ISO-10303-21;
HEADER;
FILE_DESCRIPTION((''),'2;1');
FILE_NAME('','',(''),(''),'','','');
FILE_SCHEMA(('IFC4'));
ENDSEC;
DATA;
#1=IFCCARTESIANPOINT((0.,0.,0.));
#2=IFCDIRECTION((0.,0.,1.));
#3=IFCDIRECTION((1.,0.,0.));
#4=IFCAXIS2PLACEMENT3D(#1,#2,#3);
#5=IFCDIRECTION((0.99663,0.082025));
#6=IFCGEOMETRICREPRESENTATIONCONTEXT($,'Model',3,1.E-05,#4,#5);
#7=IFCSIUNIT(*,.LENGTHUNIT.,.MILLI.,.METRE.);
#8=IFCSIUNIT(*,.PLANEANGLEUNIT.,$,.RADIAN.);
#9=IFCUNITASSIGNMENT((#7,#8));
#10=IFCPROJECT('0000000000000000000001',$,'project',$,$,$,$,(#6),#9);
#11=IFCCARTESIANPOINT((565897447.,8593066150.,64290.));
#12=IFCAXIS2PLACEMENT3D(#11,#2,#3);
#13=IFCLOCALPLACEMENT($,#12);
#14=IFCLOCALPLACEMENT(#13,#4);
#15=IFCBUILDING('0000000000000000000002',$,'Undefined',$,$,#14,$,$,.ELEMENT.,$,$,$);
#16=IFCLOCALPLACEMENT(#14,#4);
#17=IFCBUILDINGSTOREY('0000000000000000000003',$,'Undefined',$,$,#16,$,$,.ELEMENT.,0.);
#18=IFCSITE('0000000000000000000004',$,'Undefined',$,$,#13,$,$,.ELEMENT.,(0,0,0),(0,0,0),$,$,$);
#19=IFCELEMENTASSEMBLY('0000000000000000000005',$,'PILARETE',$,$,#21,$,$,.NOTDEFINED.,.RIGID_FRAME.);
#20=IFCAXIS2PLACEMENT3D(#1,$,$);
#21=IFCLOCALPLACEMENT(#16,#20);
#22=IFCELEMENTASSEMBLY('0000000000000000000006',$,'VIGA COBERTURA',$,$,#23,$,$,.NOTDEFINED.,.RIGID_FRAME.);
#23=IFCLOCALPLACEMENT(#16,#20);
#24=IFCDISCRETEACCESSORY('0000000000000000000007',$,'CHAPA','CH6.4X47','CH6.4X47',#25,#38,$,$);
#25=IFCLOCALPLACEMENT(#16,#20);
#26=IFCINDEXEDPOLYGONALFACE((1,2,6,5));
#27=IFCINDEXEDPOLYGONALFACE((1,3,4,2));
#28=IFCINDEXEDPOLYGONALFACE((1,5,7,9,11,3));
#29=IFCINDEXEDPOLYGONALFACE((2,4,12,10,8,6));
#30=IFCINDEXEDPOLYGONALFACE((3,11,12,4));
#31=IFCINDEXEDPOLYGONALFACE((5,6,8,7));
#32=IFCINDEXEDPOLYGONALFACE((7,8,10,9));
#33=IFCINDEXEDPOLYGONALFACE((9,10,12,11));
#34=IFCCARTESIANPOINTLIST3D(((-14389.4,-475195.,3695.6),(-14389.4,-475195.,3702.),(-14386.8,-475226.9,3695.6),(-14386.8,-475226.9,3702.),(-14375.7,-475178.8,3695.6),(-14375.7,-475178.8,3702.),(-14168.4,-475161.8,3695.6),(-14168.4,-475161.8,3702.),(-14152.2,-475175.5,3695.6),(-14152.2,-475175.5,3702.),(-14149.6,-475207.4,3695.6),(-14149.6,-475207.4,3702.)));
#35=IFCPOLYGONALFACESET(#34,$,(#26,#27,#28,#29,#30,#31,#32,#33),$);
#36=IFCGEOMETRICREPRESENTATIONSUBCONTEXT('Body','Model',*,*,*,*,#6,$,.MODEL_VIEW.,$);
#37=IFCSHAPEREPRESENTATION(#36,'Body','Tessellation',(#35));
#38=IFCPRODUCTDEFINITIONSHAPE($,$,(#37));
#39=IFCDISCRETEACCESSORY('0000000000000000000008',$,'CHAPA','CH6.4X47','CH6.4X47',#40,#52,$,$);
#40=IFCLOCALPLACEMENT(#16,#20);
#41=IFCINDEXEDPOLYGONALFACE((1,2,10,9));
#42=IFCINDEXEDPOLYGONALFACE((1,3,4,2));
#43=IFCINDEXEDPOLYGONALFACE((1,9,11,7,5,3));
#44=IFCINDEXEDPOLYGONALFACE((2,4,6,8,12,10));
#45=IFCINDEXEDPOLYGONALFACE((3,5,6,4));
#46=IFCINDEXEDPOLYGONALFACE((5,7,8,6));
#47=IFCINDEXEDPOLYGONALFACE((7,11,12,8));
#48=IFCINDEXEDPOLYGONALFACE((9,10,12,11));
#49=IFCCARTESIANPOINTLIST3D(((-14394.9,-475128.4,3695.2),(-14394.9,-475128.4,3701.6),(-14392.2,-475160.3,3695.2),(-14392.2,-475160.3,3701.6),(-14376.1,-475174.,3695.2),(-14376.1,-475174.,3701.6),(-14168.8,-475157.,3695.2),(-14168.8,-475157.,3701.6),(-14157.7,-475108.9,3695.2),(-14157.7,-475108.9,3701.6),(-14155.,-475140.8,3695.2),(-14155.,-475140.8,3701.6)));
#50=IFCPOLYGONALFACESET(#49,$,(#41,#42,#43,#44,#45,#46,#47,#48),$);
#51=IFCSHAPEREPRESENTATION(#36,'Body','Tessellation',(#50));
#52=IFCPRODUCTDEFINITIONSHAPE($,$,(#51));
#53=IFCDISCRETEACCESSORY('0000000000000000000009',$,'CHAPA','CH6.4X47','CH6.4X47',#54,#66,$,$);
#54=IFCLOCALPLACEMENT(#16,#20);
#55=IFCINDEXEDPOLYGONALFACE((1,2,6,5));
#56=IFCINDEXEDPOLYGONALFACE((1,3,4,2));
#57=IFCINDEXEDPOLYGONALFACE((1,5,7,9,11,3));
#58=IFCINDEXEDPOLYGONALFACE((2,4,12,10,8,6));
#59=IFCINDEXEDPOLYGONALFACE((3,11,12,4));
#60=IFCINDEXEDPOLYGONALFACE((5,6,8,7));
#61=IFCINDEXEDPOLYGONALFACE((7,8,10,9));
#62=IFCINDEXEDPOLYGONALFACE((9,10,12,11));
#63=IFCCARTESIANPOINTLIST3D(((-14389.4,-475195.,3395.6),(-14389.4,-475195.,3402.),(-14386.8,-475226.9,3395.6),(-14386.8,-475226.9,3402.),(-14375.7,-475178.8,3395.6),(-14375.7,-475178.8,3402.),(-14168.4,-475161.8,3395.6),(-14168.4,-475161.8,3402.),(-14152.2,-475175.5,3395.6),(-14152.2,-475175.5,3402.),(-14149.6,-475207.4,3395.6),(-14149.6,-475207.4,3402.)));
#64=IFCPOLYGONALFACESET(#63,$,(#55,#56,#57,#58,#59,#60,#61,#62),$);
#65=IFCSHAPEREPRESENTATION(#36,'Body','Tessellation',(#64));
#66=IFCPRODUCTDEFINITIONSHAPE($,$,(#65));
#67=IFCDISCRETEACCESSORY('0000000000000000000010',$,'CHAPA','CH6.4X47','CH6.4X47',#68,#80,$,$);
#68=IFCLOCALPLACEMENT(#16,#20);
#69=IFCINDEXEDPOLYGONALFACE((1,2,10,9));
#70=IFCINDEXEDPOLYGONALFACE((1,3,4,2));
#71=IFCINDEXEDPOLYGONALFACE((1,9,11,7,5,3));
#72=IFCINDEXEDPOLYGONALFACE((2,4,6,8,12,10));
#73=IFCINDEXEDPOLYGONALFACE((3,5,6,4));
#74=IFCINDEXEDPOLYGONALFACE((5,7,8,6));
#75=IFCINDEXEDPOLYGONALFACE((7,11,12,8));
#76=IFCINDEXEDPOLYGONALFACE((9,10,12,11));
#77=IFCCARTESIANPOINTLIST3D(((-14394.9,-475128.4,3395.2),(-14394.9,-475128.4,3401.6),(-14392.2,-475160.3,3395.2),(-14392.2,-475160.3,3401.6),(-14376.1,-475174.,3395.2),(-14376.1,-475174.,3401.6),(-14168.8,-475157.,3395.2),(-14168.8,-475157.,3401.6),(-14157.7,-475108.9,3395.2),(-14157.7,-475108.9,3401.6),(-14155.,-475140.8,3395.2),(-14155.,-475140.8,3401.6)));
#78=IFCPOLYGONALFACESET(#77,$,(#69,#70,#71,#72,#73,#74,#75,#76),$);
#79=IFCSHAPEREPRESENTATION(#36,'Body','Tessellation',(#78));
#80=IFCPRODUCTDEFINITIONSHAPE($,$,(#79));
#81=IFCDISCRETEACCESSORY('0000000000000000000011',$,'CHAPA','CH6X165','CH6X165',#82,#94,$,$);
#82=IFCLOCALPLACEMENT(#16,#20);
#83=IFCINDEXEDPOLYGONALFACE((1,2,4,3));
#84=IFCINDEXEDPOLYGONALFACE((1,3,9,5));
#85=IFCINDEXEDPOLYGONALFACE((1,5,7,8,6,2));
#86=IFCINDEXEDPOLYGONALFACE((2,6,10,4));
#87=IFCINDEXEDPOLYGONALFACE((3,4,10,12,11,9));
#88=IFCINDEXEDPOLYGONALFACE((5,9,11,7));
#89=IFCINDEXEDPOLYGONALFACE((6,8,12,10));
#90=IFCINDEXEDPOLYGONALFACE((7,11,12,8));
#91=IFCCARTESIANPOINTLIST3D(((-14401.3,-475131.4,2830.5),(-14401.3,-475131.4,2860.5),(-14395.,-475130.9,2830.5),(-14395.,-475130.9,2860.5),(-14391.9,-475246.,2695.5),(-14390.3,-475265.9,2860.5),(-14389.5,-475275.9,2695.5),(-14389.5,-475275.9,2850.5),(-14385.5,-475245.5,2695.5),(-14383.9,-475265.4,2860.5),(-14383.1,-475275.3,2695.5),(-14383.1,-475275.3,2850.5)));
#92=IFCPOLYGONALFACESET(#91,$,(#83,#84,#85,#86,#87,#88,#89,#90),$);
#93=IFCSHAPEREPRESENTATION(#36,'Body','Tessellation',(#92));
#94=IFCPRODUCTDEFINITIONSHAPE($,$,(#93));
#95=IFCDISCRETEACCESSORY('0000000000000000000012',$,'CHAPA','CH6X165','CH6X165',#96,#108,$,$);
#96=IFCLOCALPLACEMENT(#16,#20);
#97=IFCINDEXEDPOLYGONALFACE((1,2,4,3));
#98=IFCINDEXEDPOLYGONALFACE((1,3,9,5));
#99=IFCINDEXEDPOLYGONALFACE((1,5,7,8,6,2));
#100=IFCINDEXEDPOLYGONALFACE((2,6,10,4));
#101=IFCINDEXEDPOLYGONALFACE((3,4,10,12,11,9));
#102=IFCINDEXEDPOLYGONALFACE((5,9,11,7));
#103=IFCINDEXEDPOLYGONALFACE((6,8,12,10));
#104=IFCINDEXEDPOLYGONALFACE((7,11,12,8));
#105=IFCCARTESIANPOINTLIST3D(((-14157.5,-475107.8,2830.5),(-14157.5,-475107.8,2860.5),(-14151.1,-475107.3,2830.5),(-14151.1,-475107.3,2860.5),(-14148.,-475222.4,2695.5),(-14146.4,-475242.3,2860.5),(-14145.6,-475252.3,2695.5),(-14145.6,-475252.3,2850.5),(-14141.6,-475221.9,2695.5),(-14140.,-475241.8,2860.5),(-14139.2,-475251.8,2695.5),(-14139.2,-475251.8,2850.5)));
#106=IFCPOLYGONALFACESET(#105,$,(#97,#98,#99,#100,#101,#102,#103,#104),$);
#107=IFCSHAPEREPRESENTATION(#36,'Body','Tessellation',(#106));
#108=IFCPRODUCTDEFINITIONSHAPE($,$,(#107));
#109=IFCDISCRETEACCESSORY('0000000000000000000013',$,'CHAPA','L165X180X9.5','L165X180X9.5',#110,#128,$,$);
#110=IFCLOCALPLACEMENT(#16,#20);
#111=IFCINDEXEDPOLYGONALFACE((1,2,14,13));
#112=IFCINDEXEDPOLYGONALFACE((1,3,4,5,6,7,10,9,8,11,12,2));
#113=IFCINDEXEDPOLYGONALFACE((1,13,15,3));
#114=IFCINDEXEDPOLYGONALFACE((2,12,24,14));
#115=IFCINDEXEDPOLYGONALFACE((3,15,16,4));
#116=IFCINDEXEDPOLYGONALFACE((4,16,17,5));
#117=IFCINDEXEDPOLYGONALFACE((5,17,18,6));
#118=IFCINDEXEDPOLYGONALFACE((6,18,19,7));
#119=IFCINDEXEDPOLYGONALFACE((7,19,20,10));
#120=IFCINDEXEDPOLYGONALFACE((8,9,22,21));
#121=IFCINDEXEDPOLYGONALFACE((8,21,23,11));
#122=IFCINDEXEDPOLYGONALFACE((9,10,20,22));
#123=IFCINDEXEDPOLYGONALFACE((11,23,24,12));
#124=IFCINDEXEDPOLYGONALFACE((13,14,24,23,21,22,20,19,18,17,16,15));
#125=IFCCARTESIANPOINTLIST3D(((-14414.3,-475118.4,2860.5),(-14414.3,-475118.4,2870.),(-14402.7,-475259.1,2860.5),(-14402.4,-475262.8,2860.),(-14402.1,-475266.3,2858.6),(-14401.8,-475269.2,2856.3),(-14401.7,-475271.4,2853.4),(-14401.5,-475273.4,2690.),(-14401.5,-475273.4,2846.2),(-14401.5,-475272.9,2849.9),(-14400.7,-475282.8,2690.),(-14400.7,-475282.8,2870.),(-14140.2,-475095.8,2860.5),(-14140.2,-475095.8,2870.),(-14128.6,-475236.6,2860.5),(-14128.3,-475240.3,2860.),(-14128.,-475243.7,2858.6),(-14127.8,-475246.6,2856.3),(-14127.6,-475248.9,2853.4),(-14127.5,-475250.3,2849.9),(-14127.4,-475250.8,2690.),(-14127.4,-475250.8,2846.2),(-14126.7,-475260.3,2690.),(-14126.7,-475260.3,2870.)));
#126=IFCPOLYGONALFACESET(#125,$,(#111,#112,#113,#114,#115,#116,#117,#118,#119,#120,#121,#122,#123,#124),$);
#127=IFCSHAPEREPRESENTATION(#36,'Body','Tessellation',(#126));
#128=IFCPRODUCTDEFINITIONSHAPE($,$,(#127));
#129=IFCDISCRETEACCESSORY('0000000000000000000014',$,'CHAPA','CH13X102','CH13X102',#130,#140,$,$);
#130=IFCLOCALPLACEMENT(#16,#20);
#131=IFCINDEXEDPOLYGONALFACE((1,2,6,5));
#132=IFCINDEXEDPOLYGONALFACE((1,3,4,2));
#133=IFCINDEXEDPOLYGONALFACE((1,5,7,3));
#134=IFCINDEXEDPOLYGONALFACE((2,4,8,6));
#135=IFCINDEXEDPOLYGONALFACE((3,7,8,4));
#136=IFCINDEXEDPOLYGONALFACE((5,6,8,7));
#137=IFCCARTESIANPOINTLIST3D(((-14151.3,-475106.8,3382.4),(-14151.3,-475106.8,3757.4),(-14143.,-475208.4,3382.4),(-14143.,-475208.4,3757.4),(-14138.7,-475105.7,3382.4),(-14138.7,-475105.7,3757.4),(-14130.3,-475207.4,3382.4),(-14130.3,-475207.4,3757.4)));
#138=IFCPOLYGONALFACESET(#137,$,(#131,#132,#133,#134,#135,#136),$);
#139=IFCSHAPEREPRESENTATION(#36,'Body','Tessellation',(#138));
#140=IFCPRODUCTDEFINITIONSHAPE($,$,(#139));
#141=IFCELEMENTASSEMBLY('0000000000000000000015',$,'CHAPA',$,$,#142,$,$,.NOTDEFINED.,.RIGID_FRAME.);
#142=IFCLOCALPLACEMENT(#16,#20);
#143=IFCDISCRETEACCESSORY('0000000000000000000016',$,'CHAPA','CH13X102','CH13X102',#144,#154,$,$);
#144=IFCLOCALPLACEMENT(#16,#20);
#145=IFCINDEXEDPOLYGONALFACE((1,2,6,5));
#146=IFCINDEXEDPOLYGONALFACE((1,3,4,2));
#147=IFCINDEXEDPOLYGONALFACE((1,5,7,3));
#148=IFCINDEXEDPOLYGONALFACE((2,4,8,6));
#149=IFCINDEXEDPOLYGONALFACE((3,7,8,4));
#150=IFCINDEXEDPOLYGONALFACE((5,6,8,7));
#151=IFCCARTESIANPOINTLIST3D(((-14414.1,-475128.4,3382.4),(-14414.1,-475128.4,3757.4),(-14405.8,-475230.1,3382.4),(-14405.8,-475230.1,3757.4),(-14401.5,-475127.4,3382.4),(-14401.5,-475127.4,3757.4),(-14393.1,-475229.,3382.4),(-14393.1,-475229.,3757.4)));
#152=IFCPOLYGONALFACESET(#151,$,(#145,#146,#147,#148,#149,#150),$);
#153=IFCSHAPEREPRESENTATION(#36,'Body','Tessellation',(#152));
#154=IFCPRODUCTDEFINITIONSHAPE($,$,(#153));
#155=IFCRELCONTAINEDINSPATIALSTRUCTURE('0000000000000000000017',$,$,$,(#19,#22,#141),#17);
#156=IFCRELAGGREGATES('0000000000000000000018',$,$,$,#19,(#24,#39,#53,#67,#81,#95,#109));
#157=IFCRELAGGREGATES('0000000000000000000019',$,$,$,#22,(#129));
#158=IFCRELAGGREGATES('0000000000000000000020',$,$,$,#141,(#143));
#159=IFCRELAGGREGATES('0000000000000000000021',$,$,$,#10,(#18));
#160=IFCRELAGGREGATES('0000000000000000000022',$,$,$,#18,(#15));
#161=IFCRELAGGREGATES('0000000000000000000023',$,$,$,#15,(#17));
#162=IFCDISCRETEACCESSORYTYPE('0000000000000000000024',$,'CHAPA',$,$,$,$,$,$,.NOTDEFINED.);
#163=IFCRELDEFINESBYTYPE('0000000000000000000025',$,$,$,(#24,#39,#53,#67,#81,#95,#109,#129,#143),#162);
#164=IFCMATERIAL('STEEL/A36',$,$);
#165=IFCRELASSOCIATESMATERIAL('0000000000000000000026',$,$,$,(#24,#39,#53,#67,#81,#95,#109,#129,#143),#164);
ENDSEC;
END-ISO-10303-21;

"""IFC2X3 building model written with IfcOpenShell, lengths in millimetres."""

from ifc_helpers import new_model, si_unit, direction, frame, origin_with_axes, origin_2d_with_axis, place, context, subcontext, project, spatial, polyline, l_section, outline, extrude, material, type_object, element, aggregate, save


model = new_model("IFC2X3")

# Units and contexts
model_context = context("Model", 3, precision=1e-05, world=origin_with_axes(), true_north=direction((0.99663, 0.082025)))
body_context = subcontext(model_context, "Body", "Model", "MODEL_VIEW")
ifc_project = project(units=[si_unit("LENGTHUNIT", "METRE", prefix="MILLI"), si_unit("PLANEANGLEUNIT", "RADIAN")], contexts=[model_context])

# Site, building, storey
site_placement = place(None, frame((565897447.0, 8593066150.0, 64290.0), z_axis=(0.0, 0.0, 1.0), x_axis=(1.0, 0.0, 0.0)))
site = spatial("IfcSite", under=ifc_project, at=site_placement, Name="Undefined", CompositionType="ELEMENT", RefLatitude=(0, 0, 0), RefLongitude=(0, 0, 0))
building_placement = place(site_placement, origin_with_axes())
building = spatial("IfcBuilding", under=site, at=building_placement, Name="Undefined", CompositionType="ELEMENT")
storey_placement = place(building_placement, origin_with_axes())
storey = spatial("IfcBuildingStorey", under=building, at=storey_placement, Name="Undefined", CompositionType="ELEMENT", Elevation=0.0)

# Element assembly
assembly_1_placement = place(storey_placement, origin_with_axes())
assembly_1 = element("IfcElementAssembly", 1, at=assembly_1_placement, inside=storey, Name="PILARETE", AssemblyPlace="NOTDEFINED", PredefinedType="RIGID_FRAME")

# Element assembly
ifc_material_1 = material(Name="STEEL/A36")
assembly_2_placement = place(storey_placement, origin_with_axes())
assembly_2 = element("IfcElementAssembly", 2, at=assembly_2_placement, inside=storey, Name="VIGA COBERTURA", AssemblyPlace="NOTDEFINED", PredefinedType="RIGID_FRAME")

# Discrete accessories
discrete_accessory_type_1 = type_object("IfcDiscreteAccessoryType", Name="CHAPA")
discrete_accessory_1_placement = place(assembly_1_placement, frame((-14153.4, -475160.5, 3698.8), z_axis=(0.0, 0.0, -1.0), x_axis=(0.082025, -0.99663, 0.0)))
discrete_accessory_1 = element("IfcDiscreteAccessory", 3, at=discrete_accessory_1_placement, type_object=discrete_accessory_type_1, material=ifc_material_1, Name="CHAPA", Description="CH6.4X47", ObjectType="CH6.4X47", context=body_context, shape_type="SweptSolid", body=[
    extrude(outline(polyline([(0.0, 15.0), (15.0, 0.0), (47.0, 0.0), (47.0, 238.0), (15.0, 238.0), (0.0, 223.0), (0.0, 15.0)])), frame((0.0, 0.0, -3.2), z_axis=(0.0, 0.0, 1.0), x_axis=(1.0, 0.0, 0.0)), (0.0, 0.0, 1.0), 6.4),
])
discrete_accessory_2_placement = place(assembly_1_placement, frame((-14153.8, -475155.7, 3698.4), z_axis=(0.0, 0.0, 1.0), x_axis=(-0.082025, 0.99663, 0.0)))
discrete_accessory_2 = element("IfcDiscreteAccessory", 4, at=discrete_accessory_2_placement, type_object=discrete_accessory_type_1, material=ifc_material_1, Name="CHAPA", Description="CH6.4X47", ObjectType="CH6.4X47", context=body_context, shape_type="SweptSolid", body=[
    extrude(outline(polyline([(0.0, 15.0), (15.0, 0.0), (47.0, 0.0), (47.0, 238.0), (15.0, 238.0), (0.0, 223.0), (0.0, 15.0)])), frame((0.0, 0.0, -3.2), z_axis=(0.0, 0.0, 1.0), x_axis=(1.0, 0.0, 0.0)), (0.0, 0.0, 1.0), 6.4),
])
discrete_accessory_3_placement = place(assembly_1_placement, frame((-14153.4, -475160.5, 3398.8), z_axis=(0.0, 0.0, -1.0), x_axis=(0.082025, -0.99663, 0.0)))
discrete_accessory_3 = element("IfcDiscreteAccessory", 5, at=discrete_accessory_3_placement, type_object=discrete_accessory_type_1, material=ifc_material_1, Name="CHAPA", Description="CH6.4X47", ObjectType="CH6.4X47", context=body_context, shape_type="SweptSolid", body=[
    extrude(outline(polyline([(0.0, 15.0), (15.0, 0.0), (47.0, 0.0), (47.0, 238.0), (15.0, 238.0), (0.0, 223.0), (0.0, 15.0)])), frame((0.0, 0.0, -3.2), z_axis=(0.0, 0.0, 1.0), x_axis=(1.0, 0.0, 0.0)), (0.0, 0.0, 1.0), 6.4),
])
discrete_accessory_4_placement = place(assembly_1_placement, frame((-14153.8, -475155.7, 3398.4), z_axis=(0.0, 0.0, 1.0), x_axis=(-0.082025, 0.99663, 0.0)))
discrete_accessory_4 = element("IfcDiscreteAccessory", 6, at=discrete_accessory_4_placement, type_object=discrete_accessory_type_1, material=ifc_material_1, Name="CHAPA", Description="CH6.4X47", ObjectType="CH6.4X47", context=body_context, shape_type="SweptSolid", body=[
    extrude(outline(polyline([(0.0, 15.0), (15.0, 0.0), (47.0, 0.0), (47.0, 238.0), (15.0, 238.0), (0.0, 223.0), (0.0, 15.0)])), frame((0.0, 0.0, -3.2), z_axis=(0.0, 0.0, 1.0), x_axis=(1.0, 0.0, 0.0)), (0.0, 0.0, 1.0), 6.4),
])
discrete_accessory_5_placement = place(assembly_1_placement, frame((-14386.3, -475275.6, 2860.5), z_axis=(0.99663, 0.082025, -0.000004), x_axis=(-0.000004, 0.0, -1.0)))
discrete_accessory_5 = element("IfcDiscreteAccessory", 7, at=discrete_accessory_5_placement, type_object=discrete_accessory_type_1, material=ifc_material_1, Name="CHAPA", Description="CH6X165", ObjectType="CH6X165", context=body_context, shape_type="SweptSolid", body=[
    extrude(outline(polyline([(0.0, 10.0), (10.0, 0.0), (165.0, 0.0), (165.0, 30.0), (30.0, 145.0), (0.0, 145.0), (0.0, 10.0)])), frame((0.0, 0.0, -3.2), z_axis=(0.0, 0.0, 1.0), x_axis=(1.0, 0.0, 0.0)), (0.0, 0.0, 1.0), 6.4),
])
discrete_accessory_6_placement = place(assembly_1_placement, frame((-14142.4, -475252.0, 2860.5), z_axis=(0.99663, 0.082025, 0.000004), x_axis=(0.000004, 0.0, -1.0)))
discrete_accessory_6 = element("IfcDiscreteAccessory", 8, at=discrete_accessory_6_placement, type_object=discrete_accessory_type_1, material=ifc_material_1, Name="CHAPA", Description="CH6X165", ObjectType="CH6X165", context=body_context, shape_type="SweptSolid", body=[
    extrude(outline(polyline([(0.0, 10.0), (10.0, 0.0), (165.0, 0.0), (165.0, 30.0), (30.0, 145.0), (0.0, 145.0), (0.0, 10.0)])), frame((0.0, 0.0, -3.2), z_axis=(0.0, 0.0, 1.0), x_axis=(1.0, 0.0, 0.0)), (0.0, 0.0, 1.0), 6.4),
])
discrete_accessory_7_placement = place(assembly_1_placement, frame((-14133.4, -475178.0, 2780.0), z_axis=(-0.082025, 0.99663, 0.0), x_axis=(-0.99663, -0.082025, 0.0)))
discrete_accessory_7 = element("IfcDiscreteAccessory", 9, at=discrete_accessory_7_placement, type_object=discrete_accessory_type_1, material=ifc_material_1, Name="CHAPA", Description="L165X180X9.5", ObjectType="L165X180X9.5", context=body_context, shape_type="SweptSolid", body=[
    extrude(l_section(Depth=165.0, Width=180.0, Thickness=9.5, FilletRadius=14.2, at=origin_2d_with_axis()), frame((275.0, 0.0, 0.0), z_axis=(-1.0, 0.0, 0.0), x_axis=(0.0, -1.0, 0.0)), (0.0, 0.0, 1.0), 275.0),
])
aggregate(assembly_1, [discrete_accessory_1, discrete_accessory_2, discrete_accessory_3, discrete_accessory_4, discrete_accessory_5, discrete_accessory_6, discrete_accessory_7])
discrete_accessory_8_placement = place(assembly_2_placement, frame((-14140.8, -475157.1, 3757.4), z_axis=(-0.99663, -0.082025, 0.0), x_axis=(0.0, 0.0, -1.0)))
discrete_accessory_8 = element("IfcDiscreteAccessory", 10, at=discrete_accessory_8_placement, type_object=discrete_accessory_type_1, material=ifc_material_1, Name="CHAPA", Description="CH13X102", ObjectType="CH13X102", context=body_context, shape_type="SweptSolid", body=[
    extrude(outline(polyline([(375.0, -51.0), (0.0, -51.0), (0.0, 51.0), (375.0, 51.0), (375.0, -51.0)])), frame((0.0, 0.0, -6.3), z_axis=(0.0, 0.0, 1.0), x_axis=(1.0, 0.0, 0.0)), (0.0, 0.0, 1.0), 12.7),
])
aggregate(assembly_2, [discrete_accessory_8])

# Element assembly, discrete accessory
assembly_3_placement = place(storey_placement, origin_with_axes())
assembly_3 = element("IfcElementAssembly", 11, at=assembly_3_placement, inside=storey, Name="CHAPA", AssemblyPlace="NOTDEFINED", PredefinedType="RIGID_FRAME")
discrete_accessory_9_placement = place(assembly_3_placement, frame((-14403.6, -475178.7, 3757.4), z_axis=(-0.99663, -0.082025, 0.0), x_axis=(0.0, 0.0, -1.0)))
discrete_accessory_9 = element("IfcDiscreteAccessory", 12, at=discrete_accessory_9_placement, type_object=discrete_accessory_type_1, material=ifc_material_1, Name="CHAPA", Description="CH13X102", ObjectType="CH13X102", context=body_context, shape_type="SweptSolid", body=[
    extrude(outline(polyline([(375.0, -51.0), (0.0, -51.0), (0.0, 51.0), (375.0, 51.0), (375.0, -51.0)])), frame((0.0, 0.0, -6.3), z_axis=(0.0, 0.0, 1.0), x_axis=(1.0, 0.0, 0.0)), (0.0, 0.0, 1.0), 12.7),
])
aggregate(assembly_3, [discrete_accessory_9])

save(model, "model.ifc")
